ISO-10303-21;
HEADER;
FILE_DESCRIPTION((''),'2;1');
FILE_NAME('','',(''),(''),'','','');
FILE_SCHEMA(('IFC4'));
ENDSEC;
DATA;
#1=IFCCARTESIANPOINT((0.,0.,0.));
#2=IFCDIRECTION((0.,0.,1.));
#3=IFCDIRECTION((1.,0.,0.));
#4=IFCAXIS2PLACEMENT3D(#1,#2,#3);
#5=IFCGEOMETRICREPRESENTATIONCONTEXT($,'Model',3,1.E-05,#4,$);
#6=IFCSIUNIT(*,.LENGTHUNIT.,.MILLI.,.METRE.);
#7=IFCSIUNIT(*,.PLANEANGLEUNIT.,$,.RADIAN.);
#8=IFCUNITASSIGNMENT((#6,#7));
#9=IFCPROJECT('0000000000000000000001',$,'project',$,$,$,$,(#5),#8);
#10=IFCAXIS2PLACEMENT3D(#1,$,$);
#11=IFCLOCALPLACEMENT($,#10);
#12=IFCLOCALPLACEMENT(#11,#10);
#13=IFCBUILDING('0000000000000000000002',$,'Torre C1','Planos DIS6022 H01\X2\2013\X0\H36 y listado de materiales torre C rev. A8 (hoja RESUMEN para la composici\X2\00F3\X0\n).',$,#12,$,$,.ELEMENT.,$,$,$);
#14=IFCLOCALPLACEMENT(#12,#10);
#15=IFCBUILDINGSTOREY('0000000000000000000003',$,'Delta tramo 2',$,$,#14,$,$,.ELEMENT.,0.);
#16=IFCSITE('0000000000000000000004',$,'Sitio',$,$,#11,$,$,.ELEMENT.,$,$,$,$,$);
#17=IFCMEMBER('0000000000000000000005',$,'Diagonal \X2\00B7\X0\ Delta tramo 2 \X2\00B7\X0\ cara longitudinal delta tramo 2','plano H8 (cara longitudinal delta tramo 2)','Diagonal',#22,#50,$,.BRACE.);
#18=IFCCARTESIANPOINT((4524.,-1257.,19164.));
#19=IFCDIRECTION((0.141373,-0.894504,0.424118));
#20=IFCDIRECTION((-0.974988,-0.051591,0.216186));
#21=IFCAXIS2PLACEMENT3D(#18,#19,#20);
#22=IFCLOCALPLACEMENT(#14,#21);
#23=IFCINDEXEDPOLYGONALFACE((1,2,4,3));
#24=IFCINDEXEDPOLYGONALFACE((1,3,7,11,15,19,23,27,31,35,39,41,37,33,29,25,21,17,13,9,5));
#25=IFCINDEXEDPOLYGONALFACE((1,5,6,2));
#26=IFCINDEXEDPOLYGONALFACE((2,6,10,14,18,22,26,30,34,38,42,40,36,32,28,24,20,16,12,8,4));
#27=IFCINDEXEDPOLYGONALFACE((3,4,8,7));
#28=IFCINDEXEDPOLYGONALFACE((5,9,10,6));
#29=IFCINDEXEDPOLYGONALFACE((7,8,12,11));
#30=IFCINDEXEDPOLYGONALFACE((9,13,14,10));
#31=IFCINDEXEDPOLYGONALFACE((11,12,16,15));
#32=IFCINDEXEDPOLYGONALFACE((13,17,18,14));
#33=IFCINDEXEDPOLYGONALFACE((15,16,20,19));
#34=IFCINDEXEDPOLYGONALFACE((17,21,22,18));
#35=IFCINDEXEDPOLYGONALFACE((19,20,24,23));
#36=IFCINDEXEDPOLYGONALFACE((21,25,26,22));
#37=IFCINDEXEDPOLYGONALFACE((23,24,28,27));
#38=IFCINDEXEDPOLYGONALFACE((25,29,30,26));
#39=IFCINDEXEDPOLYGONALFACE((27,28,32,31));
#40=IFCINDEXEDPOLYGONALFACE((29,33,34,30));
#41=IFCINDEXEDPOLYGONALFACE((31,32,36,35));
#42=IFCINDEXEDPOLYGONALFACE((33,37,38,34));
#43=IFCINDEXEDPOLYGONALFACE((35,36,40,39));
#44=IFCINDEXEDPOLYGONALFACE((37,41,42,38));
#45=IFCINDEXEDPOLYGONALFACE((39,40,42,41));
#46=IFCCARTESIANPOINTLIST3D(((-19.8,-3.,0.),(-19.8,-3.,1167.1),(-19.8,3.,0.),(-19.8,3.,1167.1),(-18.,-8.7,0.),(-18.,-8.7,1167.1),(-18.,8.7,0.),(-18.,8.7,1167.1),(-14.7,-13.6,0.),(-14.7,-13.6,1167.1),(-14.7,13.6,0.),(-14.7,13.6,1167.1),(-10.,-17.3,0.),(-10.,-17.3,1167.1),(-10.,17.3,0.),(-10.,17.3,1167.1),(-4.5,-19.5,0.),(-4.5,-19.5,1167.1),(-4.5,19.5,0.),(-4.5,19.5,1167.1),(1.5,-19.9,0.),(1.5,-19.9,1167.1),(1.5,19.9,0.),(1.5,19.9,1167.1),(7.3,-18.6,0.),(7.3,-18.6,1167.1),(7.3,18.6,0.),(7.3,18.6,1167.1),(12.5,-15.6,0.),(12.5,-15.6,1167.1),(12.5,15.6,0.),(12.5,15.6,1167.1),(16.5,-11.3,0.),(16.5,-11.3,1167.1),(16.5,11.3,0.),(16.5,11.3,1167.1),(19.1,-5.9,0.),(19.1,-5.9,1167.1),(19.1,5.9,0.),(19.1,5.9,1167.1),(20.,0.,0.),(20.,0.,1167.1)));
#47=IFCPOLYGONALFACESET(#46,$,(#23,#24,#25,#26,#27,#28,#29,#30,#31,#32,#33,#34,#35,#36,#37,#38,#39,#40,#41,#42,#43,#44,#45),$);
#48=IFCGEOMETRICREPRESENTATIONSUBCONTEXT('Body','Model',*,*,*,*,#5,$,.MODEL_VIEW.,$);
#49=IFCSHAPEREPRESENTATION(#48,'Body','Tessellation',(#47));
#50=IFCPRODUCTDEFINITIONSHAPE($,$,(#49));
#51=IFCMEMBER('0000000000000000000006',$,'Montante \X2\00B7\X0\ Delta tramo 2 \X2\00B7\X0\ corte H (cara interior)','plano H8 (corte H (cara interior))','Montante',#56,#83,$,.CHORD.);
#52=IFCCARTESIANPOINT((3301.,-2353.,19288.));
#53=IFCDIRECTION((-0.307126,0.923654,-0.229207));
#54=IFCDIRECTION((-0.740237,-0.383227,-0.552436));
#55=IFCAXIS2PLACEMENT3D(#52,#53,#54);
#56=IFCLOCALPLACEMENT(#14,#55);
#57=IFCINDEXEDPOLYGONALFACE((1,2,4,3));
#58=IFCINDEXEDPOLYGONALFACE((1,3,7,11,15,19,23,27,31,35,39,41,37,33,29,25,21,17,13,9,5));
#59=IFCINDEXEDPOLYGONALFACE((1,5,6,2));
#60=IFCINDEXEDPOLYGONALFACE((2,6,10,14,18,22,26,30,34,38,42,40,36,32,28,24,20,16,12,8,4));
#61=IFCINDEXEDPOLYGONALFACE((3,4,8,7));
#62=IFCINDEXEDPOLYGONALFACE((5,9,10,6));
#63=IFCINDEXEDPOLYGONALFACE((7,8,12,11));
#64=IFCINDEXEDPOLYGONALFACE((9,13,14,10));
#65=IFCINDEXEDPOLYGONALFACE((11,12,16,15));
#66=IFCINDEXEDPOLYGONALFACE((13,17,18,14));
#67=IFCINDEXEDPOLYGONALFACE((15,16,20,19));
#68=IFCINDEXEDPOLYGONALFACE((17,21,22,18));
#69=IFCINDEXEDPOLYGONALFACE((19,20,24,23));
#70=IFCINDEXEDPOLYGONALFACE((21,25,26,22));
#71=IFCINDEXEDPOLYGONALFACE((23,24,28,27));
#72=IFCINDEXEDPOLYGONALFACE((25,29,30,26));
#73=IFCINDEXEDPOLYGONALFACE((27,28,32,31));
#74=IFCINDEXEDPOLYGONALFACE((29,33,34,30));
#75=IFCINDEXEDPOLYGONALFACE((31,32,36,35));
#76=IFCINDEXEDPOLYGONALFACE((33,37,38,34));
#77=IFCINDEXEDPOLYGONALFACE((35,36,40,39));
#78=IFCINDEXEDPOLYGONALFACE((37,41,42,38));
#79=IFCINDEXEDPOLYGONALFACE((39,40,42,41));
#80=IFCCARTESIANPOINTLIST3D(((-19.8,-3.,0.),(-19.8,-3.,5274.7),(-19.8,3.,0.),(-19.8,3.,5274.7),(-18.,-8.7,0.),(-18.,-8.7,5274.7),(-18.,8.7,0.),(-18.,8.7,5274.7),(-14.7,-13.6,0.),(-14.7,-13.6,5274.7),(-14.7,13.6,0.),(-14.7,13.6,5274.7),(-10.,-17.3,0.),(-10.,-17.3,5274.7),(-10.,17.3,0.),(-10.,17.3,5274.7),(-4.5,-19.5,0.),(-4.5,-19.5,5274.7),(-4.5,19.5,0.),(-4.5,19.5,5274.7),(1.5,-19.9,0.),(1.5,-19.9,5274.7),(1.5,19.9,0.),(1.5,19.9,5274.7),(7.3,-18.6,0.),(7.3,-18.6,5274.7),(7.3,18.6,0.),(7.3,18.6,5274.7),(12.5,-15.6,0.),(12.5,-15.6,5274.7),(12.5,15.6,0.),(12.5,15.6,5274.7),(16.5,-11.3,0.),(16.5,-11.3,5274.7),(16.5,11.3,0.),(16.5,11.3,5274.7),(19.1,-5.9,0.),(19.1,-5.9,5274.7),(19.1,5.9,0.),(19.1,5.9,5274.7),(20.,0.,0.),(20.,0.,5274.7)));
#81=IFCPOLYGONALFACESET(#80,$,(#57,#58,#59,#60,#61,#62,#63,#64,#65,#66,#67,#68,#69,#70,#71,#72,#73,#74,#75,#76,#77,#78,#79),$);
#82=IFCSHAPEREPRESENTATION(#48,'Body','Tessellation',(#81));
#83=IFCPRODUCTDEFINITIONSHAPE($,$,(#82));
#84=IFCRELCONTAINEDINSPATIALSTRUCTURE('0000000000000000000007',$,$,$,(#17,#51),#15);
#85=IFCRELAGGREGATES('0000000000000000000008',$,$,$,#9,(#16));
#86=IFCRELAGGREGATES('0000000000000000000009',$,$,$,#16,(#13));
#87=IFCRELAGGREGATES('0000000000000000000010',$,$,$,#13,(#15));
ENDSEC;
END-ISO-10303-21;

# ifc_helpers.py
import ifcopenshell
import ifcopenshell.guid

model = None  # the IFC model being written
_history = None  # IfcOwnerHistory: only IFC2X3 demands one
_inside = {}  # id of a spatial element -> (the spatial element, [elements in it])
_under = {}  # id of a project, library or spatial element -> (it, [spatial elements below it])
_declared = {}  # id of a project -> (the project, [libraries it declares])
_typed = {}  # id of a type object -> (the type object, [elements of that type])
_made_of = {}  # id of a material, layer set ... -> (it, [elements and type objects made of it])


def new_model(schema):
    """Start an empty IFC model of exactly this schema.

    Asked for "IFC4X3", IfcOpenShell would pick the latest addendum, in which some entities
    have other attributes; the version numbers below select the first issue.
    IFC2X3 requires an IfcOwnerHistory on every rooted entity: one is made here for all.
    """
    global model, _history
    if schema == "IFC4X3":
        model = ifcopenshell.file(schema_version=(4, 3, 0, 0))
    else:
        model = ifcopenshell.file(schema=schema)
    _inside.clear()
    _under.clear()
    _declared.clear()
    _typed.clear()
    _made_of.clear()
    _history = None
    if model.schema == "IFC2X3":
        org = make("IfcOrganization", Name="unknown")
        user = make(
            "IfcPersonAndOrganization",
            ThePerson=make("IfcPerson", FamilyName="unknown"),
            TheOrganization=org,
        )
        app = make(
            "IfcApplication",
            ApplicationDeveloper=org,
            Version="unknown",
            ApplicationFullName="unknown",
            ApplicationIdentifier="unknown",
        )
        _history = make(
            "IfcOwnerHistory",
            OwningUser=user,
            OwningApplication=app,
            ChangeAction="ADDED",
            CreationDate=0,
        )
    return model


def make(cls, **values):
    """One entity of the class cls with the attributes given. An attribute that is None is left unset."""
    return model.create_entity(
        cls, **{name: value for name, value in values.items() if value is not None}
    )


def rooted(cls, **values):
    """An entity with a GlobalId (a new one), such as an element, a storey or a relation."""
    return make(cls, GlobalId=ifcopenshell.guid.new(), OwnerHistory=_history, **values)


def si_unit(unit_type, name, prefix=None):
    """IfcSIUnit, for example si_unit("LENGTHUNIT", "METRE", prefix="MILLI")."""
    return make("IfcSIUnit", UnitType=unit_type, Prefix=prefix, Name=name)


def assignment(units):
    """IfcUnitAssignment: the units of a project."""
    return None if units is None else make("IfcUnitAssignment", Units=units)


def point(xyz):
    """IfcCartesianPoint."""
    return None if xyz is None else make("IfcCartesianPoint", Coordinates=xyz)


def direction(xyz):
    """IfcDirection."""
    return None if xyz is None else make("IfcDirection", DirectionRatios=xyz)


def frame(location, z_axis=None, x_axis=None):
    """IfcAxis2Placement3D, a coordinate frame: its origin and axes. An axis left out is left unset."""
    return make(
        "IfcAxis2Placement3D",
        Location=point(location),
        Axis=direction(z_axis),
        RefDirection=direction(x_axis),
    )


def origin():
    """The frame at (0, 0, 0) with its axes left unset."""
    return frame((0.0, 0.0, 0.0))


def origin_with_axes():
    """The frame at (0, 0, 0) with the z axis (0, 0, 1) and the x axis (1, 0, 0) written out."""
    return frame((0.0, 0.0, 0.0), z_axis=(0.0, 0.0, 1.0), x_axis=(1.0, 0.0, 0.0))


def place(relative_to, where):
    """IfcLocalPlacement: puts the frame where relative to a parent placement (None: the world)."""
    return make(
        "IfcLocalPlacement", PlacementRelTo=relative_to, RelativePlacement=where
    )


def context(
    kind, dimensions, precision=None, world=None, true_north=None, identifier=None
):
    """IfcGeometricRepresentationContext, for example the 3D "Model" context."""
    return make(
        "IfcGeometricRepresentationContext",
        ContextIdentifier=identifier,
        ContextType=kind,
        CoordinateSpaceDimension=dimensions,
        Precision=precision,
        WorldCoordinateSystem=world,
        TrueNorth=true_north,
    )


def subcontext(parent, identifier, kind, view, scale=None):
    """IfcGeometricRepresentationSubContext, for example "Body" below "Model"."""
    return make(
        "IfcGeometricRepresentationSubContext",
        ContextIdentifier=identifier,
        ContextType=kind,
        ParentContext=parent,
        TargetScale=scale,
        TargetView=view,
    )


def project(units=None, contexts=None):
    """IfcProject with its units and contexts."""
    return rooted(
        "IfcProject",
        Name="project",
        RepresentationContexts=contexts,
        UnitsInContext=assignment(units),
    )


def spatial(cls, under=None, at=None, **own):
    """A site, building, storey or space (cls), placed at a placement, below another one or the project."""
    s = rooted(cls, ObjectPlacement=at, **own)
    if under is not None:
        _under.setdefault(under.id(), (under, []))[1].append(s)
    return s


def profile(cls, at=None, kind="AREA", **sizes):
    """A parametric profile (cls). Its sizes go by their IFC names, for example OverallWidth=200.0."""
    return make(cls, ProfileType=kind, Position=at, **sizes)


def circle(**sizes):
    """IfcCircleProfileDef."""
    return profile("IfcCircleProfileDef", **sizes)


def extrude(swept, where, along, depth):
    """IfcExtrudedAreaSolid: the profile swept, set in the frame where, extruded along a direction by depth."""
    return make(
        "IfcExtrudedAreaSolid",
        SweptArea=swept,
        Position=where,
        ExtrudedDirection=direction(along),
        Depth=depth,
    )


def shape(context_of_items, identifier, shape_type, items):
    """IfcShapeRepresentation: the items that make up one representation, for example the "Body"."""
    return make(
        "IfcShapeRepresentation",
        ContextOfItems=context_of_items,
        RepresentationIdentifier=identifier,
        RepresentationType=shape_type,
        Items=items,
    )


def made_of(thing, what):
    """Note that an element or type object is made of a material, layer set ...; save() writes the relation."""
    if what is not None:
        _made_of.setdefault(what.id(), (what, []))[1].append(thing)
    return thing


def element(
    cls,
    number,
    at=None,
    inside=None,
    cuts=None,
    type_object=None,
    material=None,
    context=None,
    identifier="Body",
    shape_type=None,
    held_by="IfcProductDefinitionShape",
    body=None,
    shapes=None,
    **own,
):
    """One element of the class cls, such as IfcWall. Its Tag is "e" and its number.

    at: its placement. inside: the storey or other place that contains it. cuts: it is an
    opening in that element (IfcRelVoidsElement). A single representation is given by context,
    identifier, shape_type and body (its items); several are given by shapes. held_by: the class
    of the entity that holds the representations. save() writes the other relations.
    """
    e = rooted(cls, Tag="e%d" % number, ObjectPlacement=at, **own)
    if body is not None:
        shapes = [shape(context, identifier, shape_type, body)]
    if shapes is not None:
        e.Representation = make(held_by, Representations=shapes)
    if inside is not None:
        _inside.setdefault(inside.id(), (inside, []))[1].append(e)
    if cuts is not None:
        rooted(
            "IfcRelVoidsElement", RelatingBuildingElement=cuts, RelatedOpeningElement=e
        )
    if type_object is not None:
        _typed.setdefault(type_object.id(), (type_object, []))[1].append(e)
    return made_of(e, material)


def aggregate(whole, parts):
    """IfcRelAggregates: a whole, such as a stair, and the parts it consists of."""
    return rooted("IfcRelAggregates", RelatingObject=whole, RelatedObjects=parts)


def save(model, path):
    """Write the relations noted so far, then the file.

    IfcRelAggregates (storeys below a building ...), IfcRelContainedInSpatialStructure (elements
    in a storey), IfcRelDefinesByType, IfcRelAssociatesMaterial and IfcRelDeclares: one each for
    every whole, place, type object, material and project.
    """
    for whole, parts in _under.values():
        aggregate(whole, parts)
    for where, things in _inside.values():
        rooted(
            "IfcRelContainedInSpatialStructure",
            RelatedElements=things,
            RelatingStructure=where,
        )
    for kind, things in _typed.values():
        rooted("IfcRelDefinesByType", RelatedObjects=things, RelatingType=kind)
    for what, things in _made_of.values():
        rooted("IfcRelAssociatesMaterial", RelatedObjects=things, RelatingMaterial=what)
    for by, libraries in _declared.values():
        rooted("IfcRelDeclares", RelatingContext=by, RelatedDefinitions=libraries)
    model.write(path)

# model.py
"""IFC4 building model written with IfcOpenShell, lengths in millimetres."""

from ifc_helpers import new_model, si_unit, frame, origin, origin_with_axes, place, context, subcontext, project, spatial, circle, extrude, element, save


model = new_model("IFC4")

# Units and contexts
model_context = context("Model", 3, precision=1e-05, world=origin_with_axes())
body_context = subcontext(model_context, "Body", "Model", "MODEL_VIEW")
ifc_project = project(units=[si_unit("LENGTHUNIT", "METRE", prefix="MILLI"), si_unit("PLANEANGLEUNIT", "RADIAN")], contexts=[model_context])

# Site, building, storey
site_placement = place(None, origin())
site = spatial("IfcSite", under=ifc_project, at=site_placement, Name="Sitio", CompositionType="ELEMENT")
building_placement = place(site_placement, origin())
building = spatial("IfcBuilding", under=site, at=building_placement, Name="Torre C1", Description="Planos DIS6022 H01–H36 y listado de materiales torre C rev. A8 (hoja RESUMEN para la composición).", CompositionType="ELEMENT")
storey_placement = place(building_placement, origin())
storey = spatial("IfcBuildingStorey", under=building, at=storey_placement, Name="Delta tramo 2", CompositionType="ELEMENT", Elevation=0.0)

# Members
member_1_placement = place(storey_placement, frame((4524.0, -1257.0, 19164.0), z_axis=(0.141373, -0.894504, 0.424118), x_axis=(-0.974988, -0.051591, 0.216186)))
element("IfcMember", 1, at=member_1_placement, inside=storey, Name="Diagonal · Delta tramo 2 · cara longitudinal delta tramo 2", Description="plano H8 (cara longitudinal delta tramo 2)", ObjectType="Diagonal", PredefinedType="BRACE", context=body_context, shape_type="SweptSolid", body=[
    extrude(circle(Radius=20.0), None, (0.0, 0.0, 1.0), 1167.1),
])
member_2_placement = place(storey_placement, frame((3301.0, -2353.0, 19288.0), z_axis=(-0.307126, 0.923654, -0.229207), x_axis=(-0.740237, -0.383227, -0.552436)))
element("IfcMember", 2, at=member_2_placement, inside=storey, Name="Montante · Delta tramo 2 · corte H (cara interior)", Description="plano H8 (corte H (cara interior))", ObjectType="Montante", PredefinedType="CHORD", context=body_context, shape_type="SweptSolid", body=[
    extrude(circle(Radius=20.0), None, (0.0, 0.0, 1.0), 5274.7),
])

save(model, "model.ifc")
